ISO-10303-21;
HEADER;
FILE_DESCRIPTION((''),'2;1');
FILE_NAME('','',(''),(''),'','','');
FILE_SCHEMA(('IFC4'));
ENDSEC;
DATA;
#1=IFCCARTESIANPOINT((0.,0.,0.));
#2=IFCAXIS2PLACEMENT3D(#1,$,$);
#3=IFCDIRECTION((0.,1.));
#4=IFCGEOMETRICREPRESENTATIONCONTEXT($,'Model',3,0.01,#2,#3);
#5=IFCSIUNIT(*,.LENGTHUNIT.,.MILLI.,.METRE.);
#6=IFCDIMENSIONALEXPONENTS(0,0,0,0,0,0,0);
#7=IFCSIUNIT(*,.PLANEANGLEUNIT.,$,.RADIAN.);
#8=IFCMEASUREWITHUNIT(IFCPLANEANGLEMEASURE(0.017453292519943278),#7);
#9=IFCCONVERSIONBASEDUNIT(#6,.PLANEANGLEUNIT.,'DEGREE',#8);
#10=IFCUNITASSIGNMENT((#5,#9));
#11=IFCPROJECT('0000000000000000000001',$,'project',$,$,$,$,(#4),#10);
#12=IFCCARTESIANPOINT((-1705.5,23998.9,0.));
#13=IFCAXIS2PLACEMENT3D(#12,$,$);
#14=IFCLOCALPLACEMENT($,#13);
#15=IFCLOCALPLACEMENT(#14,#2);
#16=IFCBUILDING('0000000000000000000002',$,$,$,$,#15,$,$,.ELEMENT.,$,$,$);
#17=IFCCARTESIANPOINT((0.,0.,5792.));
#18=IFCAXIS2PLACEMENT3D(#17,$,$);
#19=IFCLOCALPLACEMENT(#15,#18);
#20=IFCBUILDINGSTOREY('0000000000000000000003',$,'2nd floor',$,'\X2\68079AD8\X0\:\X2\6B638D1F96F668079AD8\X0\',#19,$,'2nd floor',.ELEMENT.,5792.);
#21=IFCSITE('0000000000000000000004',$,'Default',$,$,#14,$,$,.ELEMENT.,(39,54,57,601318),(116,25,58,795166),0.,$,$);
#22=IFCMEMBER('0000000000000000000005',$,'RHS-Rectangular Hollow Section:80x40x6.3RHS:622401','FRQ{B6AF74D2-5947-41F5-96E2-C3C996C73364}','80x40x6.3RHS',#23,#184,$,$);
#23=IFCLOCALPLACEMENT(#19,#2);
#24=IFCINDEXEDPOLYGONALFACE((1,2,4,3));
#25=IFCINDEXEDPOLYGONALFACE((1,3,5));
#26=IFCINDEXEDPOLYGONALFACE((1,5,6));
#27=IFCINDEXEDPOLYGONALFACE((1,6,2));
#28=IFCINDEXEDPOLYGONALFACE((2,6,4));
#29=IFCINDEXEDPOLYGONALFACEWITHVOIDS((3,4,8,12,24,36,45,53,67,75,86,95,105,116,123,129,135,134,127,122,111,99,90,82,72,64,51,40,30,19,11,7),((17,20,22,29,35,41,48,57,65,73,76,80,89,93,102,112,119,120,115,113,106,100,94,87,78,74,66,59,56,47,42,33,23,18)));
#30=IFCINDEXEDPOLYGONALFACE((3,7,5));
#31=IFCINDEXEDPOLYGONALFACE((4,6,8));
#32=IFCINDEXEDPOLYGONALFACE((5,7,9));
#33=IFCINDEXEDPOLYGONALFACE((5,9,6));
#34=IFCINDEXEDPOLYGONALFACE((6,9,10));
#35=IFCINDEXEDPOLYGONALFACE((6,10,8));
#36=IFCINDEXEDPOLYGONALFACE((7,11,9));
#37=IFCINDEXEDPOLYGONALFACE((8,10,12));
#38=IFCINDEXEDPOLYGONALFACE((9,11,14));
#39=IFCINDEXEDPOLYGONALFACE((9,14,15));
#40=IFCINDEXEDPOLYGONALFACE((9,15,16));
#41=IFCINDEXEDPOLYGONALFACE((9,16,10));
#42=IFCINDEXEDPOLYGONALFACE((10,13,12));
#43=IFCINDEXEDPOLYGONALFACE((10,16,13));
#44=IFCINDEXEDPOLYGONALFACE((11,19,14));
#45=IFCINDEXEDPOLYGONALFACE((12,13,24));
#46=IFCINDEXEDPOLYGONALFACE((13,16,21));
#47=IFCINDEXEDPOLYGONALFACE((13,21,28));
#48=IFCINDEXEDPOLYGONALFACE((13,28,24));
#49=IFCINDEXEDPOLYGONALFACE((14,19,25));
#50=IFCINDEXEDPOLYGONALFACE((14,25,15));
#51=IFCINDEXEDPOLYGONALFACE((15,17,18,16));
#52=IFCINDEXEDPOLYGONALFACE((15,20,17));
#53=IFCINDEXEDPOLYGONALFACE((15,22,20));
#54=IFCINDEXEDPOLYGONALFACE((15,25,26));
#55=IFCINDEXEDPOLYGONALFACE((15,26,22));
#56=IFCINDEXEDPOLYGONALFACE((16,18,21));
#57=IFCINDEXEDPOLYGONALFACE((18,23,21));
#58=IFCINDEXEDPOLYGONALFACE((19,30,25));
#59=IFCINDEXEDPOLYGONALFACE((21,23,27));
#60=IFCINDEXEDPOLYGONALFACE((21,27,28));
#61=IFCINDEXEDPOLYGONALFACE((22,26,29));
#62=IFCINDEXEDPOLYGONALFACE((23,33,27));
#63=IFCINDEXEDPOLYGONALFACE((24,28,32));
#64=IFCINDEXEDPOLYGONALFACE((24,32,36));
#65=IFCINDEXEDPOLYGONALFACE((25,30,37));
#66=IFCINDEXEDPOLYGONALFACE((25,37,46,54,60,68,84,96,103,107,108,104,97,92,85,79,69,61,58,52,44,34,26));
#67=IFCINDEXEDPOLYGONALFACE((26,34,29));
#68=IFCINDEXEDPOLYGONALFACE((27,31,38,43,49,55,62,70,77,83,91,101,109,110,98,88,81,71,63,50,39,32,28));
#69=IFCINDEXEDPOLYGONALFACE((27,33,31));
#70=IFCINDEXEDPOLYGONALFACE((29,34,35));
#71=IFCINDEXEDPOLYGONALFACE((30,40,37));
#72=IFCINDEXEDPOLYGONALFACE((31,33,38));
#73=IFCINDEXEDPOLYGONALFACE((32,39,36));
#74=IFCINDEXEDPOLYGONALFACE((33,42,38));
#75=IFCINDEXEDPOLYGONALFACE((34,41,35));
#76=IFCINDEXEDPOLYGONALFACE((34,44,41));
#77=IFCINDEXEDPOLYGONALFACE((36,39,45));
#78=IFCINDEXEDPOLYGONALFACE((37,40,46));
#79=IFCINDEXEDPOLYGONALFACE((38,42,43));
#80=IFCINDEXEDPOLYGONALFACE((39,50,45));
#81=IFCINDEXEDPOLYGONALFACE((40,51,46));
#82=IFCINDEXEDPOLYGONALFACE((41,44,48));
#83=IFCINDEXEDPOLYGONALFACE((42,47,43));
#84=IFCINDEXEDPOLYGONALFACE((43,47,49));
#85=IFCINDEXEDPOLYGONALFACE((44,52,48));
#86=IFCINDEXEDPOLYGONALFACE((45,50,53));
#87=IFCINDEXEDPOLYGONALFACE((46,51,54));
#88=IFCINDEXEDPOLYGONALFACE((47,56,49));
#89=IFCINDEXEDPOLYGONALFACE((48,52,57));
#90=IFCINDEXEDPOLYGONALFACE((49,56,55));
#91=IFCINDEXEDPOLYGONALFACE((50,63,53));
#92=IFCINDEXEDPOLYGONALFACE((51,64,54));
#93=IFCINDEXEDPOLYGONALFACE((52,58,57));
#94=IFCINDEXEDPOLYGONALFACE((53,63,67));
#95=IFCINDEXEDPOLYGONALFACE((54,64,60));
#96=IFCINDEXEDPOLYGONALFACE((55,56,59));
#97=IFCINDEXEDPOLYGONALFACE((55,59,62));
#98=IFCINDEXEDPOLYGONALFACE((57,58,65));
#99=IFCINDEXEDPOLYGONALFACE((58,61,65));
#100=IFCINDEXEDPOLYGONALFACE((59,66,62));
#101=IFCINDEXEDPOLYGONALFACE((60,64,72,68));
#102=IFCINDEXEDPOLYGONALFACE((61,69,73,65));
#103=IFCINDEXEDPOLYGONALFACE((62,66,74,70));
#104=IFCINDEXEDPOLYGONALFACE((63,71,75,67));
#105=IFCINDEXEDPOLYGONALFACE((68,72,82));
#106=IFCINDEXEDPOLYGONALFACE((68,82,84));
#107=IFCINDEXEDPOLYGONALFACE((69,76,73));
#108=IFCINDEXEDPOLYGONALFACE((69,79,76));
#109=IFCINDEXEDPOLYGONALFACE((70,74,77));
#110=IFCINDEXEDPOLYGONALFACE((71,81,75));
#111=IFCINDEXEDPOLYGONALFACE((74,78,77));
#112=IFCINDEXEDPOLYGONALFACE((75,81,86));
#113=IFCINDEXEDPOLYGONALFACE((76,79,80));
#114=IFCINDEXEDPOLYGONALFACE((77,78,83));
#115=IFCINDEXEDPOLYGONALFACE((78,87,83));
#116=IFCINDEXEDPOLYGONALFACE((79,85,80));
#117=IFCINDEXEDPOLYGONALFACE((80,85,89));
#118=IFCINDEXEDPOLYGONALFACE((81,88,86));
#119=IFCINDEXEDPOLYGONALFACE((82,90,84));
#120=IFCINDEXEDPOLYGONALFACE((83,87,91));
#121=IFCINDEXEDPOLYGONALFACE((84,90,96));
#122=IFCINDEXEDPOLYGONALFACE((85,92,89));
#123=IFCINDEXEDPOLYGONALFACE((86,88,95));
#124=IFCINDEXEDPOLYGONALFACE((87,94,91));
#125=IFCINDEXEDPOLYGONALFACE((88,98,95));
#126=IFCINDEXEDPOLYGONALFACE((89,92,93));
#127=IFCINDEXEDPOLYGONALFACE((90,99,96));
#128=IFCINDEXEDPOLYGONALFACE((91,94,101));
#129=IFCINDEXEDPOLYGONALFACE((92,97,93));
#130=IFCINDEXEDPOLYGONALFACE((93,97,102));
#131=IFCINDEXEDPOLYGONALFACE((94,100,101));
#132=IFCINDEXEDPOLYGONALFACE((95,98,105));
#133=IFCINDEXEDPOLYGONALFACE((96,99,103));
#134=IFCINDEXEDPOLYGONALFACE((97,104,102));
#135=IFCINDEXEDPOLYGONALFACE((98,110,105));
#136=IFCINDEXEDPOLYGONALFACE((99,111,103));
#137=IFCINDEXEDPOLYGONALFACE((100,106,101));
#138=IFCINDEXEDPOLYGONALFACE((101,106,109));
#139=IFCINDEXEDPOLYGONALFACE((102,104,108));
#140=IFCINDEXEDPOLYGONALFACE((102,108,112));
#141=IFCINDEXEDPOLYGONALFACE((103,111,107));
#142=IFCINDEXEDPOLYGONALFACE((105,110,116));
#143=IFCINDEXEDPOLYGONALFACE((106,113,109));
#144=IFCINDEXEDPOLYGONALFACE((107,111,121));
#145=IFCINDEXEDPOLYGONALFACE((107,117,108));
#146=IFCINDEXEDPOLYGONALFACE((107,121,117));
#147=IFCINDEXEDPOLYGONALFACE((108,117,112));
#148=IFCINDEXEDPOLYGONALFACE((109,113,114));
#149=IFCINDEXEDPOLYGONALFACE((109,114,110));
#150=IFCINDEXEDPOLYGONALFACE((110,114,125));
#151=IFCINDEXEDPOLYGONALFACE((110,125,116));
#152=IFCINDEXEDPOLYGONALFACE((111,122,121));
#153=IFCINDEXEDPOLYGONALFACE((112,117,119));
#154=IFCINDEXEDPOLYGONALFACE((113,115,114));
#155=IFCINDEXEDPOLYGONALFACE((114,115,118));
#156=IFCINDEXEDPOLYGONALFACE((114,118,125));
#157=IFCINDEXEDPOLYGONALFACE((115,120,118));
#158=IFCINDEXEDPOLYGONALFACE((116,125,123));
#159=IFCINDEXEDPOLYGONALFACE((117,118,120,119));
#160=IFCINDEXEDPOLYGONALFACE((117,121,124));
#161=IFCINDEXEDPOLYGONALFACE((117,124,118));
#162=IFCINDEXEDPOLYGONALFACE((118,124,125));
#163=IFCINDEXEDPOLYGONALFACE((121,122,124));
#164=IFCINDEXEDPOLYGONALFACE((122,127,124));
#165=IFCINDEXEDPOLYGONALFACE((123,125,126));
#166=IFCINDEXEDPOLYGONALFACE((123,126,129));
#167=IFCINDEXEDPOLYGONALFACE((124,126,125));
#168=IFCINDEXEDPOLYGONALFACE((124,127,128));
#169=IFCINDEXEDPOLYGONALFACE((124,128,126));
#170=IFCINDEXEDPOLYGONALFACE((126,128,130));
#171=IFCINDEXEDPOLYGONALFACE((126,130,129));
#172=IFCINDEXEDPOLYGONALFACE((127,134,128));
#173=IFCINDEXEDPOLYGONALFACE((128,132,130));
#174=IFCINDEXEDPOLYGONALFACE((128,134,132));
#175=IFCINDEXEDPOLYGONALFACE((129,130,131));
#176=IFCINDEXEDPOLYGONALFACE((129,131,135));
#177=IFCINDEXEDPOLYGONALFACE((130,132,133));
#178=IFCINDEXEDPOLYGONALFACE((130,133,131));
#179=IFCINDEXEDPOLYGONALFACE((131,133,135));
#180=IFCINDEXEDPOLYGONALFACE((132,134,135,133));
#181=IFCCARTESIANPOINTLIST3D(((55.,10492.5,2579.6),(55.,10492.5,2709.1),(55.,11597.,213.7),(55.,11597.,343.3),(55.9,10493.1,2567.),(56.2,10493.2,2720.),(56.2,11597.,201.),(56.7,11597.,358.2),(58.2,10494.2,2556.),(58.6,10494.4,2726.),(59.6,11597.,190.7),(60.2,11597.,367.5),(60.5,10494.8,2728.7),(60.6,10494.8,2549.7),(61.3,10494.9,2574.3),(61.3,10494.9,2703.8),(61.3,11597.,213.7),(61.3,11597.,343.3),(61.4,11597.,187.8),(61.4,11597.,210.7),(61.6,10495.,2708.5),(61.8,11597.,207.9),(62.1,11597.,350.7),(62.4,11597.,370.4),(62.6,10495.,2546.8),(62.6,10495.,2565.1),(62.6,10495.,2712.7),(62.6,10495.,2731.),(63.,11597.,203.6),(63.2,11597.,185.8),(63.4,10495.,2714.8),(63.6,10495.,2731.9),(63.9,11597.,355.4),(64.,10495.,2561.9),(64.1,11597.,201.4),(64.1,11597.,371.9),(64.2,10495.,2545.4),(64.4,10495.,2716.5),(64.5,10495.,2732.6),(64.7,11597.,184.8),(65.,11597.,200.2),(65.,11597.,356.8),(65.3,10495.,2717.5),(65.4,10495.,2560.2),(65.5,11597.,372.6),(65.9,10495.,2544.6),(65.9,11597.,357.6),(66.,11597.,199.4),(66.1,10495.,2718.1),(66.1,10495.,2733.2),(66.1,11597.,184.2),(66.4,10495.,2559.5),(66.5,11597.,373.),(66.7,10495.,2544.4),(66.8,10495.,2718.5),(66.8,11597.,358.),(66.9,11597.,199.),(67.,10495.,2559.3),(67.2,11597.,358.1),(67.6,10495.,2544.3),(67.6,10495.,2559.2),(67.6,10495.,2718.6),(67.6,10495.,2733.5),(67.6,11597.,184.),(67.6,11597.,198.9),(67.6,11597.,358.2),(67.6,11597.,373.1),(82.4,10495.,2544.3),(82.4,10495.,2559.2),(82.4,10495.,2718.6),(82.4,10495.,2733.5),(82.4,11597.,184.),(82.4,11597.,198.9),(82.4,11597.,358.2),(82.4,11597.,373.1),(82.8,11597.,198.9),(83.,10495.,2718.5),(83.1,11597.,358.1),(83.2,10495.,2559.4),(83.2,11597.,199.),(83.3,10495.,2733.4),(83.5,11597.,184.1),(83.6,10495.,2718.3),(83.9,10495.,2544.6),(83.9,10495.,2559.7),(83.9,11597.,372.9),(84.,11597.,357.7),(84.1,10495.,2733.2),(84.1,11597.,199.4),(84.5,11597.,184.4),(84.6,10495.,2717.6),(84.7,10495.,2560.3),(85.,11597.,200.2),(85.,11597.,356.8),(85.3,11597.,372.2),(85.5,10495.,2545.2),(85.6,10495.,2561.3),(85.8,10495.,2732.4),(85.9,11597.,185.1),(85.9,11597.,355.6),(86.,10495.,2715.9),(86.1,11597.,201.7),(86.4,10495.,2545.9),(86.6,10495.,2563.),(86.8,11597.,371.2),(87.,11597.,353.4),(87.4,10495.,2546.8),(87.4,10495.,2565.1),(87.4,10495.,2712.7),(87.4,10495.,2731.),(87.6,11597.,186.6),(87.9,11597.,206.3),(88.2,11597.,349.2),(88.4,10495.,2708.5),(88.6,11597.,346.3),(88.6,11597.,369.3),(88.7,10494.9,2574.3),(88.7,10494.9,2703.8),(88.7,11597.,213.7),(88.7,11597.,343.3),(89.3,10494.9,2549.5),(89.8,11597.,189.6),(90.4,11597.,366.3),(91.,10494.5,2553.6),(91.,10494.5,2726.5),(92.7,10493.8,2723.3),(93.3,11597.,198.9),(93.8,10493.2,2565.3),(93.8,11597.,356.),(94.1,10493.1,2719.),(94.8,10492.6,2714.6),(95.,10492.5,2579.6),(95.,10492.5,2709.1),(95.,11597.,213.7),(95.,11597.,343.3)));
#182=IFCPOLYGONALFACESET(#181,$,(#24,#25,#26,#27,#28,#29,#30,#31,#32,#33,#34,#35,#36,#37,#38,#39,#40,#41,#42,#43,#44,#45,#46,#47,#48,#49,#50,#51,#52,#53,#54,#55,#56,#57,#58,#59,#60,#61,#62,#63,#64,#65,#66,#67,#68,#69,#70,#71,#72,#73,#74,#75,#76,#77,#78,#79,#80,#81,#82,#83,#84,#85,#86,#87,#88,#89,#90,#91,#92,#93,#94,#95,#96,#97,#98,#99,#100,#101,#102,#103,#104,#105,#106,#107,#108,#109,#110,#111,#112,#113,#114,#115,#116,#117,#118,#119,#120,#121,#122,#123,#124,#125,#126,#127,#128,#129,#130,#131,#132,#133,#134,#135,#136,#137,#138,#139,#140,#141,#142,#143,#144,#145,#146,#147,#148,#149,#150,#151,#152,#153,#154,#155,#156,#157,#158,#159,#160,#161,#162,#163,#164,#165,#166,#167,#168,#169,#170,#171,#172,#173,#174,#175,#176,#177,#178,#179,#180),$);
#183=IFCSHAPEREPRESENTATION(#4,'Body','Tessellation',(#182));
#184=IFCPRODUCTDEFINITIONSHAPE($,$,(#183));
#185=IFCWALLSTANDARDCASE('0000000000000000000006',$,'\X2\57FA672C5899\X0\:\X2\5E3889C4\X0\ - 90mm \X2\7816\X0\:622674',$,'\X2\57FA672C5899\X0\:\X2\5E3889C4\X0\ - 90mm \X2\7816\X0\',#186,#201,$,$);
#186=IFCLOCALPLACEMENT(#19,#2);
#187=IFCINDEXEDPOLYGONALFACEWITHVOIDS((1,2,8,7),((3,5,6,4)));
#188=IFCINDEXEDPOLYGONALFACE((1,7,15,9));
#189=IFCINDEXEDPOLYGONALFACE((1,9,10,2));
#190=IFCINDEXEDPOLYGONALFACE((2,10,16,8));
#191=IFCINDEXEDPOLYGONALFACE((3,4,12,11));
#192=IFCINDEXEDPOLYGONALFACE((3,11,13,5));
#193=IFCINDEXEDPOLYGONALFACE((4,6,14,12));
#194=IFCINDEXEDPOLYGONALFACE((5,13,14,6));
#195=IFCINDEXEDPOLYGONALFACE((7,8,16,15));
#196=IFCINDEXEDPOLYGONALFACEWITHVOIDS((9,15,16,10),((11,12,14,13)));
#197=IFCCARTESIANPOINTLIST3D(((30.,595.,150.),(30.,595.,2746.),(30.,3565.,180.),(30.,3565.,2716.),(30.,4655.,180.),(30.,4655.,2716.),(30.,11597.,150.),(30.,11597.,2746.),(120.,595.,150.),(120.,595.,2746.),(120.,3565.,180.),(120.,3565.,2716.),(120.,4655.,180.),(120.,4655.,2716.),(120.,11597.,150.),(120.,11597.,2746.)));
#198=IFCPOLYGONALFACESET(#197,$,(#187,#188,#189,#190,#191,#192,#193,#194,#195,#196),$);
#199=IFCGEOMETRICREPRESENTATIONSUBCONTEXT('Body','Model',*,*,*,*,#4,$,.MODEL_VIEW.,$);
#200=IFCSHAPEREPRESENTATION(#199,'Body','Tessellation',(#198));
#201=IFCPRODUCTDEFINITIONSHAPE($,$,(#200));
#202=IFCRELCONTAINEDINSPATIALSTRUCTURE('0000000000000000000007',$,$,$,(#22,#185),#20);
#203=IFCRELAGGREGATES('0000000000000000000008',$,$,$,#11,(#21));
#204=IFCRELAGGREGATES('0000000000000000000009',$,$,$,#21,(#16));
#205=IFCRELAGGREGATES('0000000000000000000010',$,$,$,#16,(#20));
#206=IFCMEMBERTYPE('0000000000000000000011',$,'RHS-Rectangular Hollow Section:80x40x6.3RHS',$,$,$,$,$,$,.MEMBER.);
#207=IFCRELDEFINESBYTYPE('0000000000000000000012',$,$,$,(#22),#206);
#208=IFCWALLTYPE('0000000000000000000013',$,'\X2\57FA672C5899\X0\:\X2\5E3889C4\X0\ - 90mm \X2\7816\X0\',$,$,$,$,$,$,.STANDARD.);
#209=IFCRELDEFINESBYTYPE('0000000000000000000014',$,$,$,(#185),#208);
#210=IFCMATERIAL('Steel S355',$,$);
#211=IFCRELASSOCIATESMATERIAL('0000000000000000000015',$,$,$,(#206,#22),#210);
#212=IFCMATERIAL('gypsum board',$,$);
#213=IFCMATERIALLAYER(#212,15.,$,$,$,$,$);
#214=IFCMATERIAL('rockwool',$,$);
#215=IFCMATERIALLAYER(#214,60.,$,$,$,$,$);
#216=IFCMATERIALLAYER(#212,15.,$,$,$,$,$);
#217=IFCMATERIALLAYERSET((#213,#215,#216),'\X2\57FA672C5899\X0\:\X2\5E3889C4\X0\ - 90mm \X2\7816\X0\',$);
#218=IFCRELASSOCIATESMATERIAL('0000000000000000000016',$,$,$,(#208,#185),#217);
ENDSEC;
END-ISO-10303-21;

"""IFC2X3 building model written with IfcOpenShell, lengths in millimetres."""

from ifc_helpers import new_model, entity, si_unit, converted_unit, point, direction, frame, frame_2d, origin, origin_2d, place, context, subcontext, project, spatial, circle_curve, line_curve, trimmed, segment, composite_curve, rectangle, hollow_rectangle, outline, extrude, clip, halfspace, material, layer, layer_set, layer_usage, type_object, element, save


model = new_model("IFC2X3")

# Units and contexts
model_context = context("Model", 3, precision=0.01, world=origin(), true_north=direction((0.0, 1.0)))
body_context = subcontext(model_context, "Body", "Model", "MODEL_VIEW")
ifc_project = project(units=[si_unit("LENGTHUNIT", "METRE", prefix="MILLI"), converted_unit("PLANEANGLEUNIT", "DEGREE", entity("IfcPlaneAngleMeasure", 0.017453292519943278), si_unit("PLANEANGLEUNIT", "RADIAN"), dimensions=[0, 0, 0, 0, 0, 0, 0])], contexts=[model_context])

# Site, building, storey
site_placement = place(None, frame((-1705.5, 23998.9, 0.0)))
site = spatial("IfcSite", under=ifc_project, at=site_placement, Name="Default", CompositionType="ELEMENT", RefLatitude=(39, 54, 57, 601318), RefLongitude=(116, 25, 58, 795166), RefElevation=0.0)
building_placement = place(site_placement, origin())
building = spatial("IfcBuilding", under=site, at=building_placement, CompositionType="ELEMENT")
storey_placement = place(building_placement, frame((0.0, 0.0, 5792.0)))
storey = spatial("IfcBuildingStorey", under=building, at=storey_placement, Name="2nd floor", ObjectType="标高:正负零标高", LongName="2nd floor", CompositionType="ELEMENT", Elevation=5792.0)

# Shared definitions
ifc_material_1 = material(Name="Steel S355")

# Member, openings
member_type_1 = type_object("IfcMemberType", Name="RHS-Rectangular Hollow Section:80x40x6.3RHS", PredefinedType="MEMBER", material=ifc_material_1)
member_1_placement = place(storey_placement, frame((75.0, 11701.7, 54.2), z_axis=(0.0, 0.423038, -0.906112), x_axis=(-1.0, 0.0, 0.0)))
member_1 = element("IfcMember", 1, at=member_1_placement, inside=storey, type_object=member_type_1, material=ifc_material_1, Name="RHS-Rectangular Hollow Section:80x40x6.3RHS:622401", Description="FRQ{B6AF74D2-5947-41F5-96E2-C3C996C73364}", ObjectType="80x40x6.3RHS", context=model_context, shape_type="Clipping", body=[
    clip(clip(extrude(hollow_rectangle(XDim=40.0, YDim=80.0, WallThickness=6.3, InnerFilletRadius=6.3, OuterFilletRadius=12.6, at=origin_2d()), origin(), (0.0, 0.0, -1.0), 3076.4), halfspace(frame((75.0, -3611.9, 4765.7), z_axis=(0.0, 0.906112, 0.423038), x_axis=(1.0, 0.0, 0.0)), True)), halfspace(frame((75.0, -2513.7, 5278.4), z_axis=(0.0, -0.906112, -0.423038), x_axis=(-1.0, 0.0, 0.0)), True)),
])
opening_1_placement = place(member_1_placement, frame((0.0, -82.3, 70.7), z_axis=(0.0, 0.423038, -0.906112), x_axis=(-1.0, 0.0, 0.0)))
element("IfcOpeningElement", 2, at=opening_1_placement, cuts=member_1, ObjectType="Opening", context=model_context, shape_type="SweptSolid", body=[
    extrude(outline(composite_curve([segment(trimmed(circle_curve(frame_2d((-12.4, -1174.6), x_axis=(1.0, 0.0)), 12.6), [point((-12.4, -1162.0))], [point((-25.0, -1174.6))], True, "CARTESIAN"), True, "CONTINUOUS"), segment(trimmed(line_curve((-25.0, -1174.6), (0.0, -1.0), 74.800002), [point((-25.0, -1174.6))], [point((-25.0, -1249.4))], True, "CARTESIAN"), True, "CONTINUOUS"), segment(trimmed(circle_curve(frame_2d((-12.4, -1249.4), x_axis=(1.0, 0.0)), 12.6), [point((-25.0, -1249.4))], [point((-12.4, -1262.0))], True, "CARTESIAN"), True, "CONTINUOUS"), segment(trimmed(line_curve((-12.4, -1262.0), (1.0, 0.0), 24.800002), [point((-12.4, -1262.0))], [point((12.4, -1262.0))], True, "CARTESIAN"), True, "CONTINUOUS"), segment(trimmed(circle_curve(frame_2d((12.4, -1249.4), x_axis=(1.0, 0.0)), 12.6), [point((12.4, -1262.0))], [point((25.0, -1249.4))], True, "CARTESIAN"), True, "CONTINUOUS"), segment(trimmed(line_curve((25.0, -1249.4), (0.0, 1.0), 74.800002), [point((25.0, -1249.4))], [point((25.0, -1174.6))], True, "CARTESIAN"), True, "CONTINUOUS"), segment(trimmed(circle_curve(frame_2d((12.4, -1174.6), x_axis=(1.0, 0.0)), 12.6), [point((25.0, -1174.6))], [point((12.4, -1162.0))], True, "CARTESIAN"), True, "CONTINUOUS"), segment(trimmed(line_curve((12.4, -1162.0), (-1.0, 0.0), 24.800002), [point((12.4, -1162.0))], [point((-12.4, -1162.0))], True, "CARTESIAN"), True, "CONTINUOUS")], self_intersect="UNKNOWN")), origin(), (0.0, 0.0, 1.0), 2985.3),
])
opening_2_placement = place(member_1_placement, frame((0.0, -82.3, 70.7), z_axis=(0.0, 0.423038, -0.906112), x_axis=(-1.0, 0.0, 0.0)))
element("IfcOpeningElement", 3, at=opening_2_placement, cuts=member_1, ObjectType="Opening", context=model_context, shape_type="SweptSolid", body=[
    extrude(outline(composite_curve([segment(trimmed(circle_curve(frame_2d((-40.0, -40.0), x_axis=(1.0, 0.0)), 20.0), [point((-60.0, -40.0))], [point((-40.0, -60.0))], True, "CARTESIAN"), True, "CONTINUOUS"), segment(trimmed(line_curve((-40.0, -60.0), (1.0, 0.0), 80.000001), [point((-40.0, -60.0))], [point((40.0, -60.0))], True, "CARTESIAN"), True, "CONTINUOUS"), segment(trimmed(circle_curve(frame_2d((40.0, -40.0), x_axis=(1.0, 0.0)), 20.0), [point((40.0, -60.0))], [point((60.0, -40.0))], True, "CARTESIAN"), True, "CONTINUOUS"), segment(trimmed(line_curve((60.0, -40.0), (0.0, 1.0), 79.999999), [point((60.0, -40.0))], [point((60.0, 40.0))], True, "CARTESIAN"), True, "CONTINUOUS"), segment(trimmed(circle_curve(frame_2d((40.0, 40.0), x_axis=(1.0, 0.0)), 20.0), [point((60.0, 40.0))], [point((40.0, 60.0))], True, "CARTESIAN"), True, "CONTINUOUS"), segment(trimmed(line_curve((40.0, 60.0), (-1.0, 0.0), 80.000001), [point((40.0, 60.0))], [point((-40.0, 60.0))], True, "CARTESIAN"), True, "CONTINUOUS"), segment(trimmed(circle_curve(frame_2d((-40.0, 40.0), x_axis=(1.0, 0.0)), 20.0), [point((-40.0, 60.0))], [point((-60.0, 40.0))], True, "CARTESIAN"), True, "CONTINUOUS"), segment(trimmed(line_curve((-60.0, 40.0), (0.0, -1.0), 79.999999), [point((-60.0, 40.0))], [point((-60.0, -40.0))], True, "CARTESIAN"), True, "CONTINUOUS")], self_intersect="UNKNOWN")), origin(), (0.0, 0.0, 1.0), 2985.3),
])

# Shared definitions
ifc_material_2 = material(Name="gypsum board")
ifc_layer_1 = layer(ifc_material_2, 15.0)
ifc_material_3 = material(Name="rockwool")
ifc_layer_2 = layer(ifc_material_3, 60.0)
ifc_layer_3 = layer(ifc_material_2, 15.0)
ifc_layer_set = layer_set([ifc_layer_1, ifc_layer_2, ifc_layer_3], Name="基本墙:常规 - 90mm 砖")
wall_type = type_object("IfcWallType", Name="基本墙:常规 - 90mm 砖", PredefinedType="STANDARD", material=ifc_layer_set)

# Wall, opening
ifc_layer_usage_1 = layer_usage(ifc_layer_set, "AXIS2", "NEGATIVE", 45.0)
wall_1_placement = place(storey_placement, frame((75.0, 11597.0, 150.0), z_axis=(0.0, 0.0, 1.0), x_axis=(0.0, -1.0, 0.0)))
wall_1 = element("IfcWallStandardCase", 4, at=wall_1_placement, inside=storey, type_object=wall_type, material=ifc_layer_usage_1, Name="基本墙:常规 - 90mm 砖:622674", ObjectType="基本墙:常规 - 90mm 砖", context=body_context, shape_type="SweptSolid", body=[
    extrude(rectangle(XDim=11002.0, YDim=90.0, at=frame_2d((5501.0, 0.0), x_axis=(-1.0, 0.0))), origin(), (0.0, 0.0, 1.0), 2596.0),
])
opening_3_placement = place(wall_1_placement, origin())
element("IfcOpeningElement", 5, at=opening_3_placement, cuts=wall_1, ObjectType="Opening", context=body_context, shape_type="SweptSolid", body=[
    extrude(rectangle(XDim=2536.0, YDim=1090.0, at=frame_2d((0.0, 0.0), x_axis=(0.0, 1.0))), frame((7487.0, 45.0, 1298.0), z_axis=(0.0, -1.0, 0.0), x_axis=(-1.0, 0.0, 0.0)), (0.0, 0.0, 1.0), 90.0),
])

save(model, "model.ifc")
